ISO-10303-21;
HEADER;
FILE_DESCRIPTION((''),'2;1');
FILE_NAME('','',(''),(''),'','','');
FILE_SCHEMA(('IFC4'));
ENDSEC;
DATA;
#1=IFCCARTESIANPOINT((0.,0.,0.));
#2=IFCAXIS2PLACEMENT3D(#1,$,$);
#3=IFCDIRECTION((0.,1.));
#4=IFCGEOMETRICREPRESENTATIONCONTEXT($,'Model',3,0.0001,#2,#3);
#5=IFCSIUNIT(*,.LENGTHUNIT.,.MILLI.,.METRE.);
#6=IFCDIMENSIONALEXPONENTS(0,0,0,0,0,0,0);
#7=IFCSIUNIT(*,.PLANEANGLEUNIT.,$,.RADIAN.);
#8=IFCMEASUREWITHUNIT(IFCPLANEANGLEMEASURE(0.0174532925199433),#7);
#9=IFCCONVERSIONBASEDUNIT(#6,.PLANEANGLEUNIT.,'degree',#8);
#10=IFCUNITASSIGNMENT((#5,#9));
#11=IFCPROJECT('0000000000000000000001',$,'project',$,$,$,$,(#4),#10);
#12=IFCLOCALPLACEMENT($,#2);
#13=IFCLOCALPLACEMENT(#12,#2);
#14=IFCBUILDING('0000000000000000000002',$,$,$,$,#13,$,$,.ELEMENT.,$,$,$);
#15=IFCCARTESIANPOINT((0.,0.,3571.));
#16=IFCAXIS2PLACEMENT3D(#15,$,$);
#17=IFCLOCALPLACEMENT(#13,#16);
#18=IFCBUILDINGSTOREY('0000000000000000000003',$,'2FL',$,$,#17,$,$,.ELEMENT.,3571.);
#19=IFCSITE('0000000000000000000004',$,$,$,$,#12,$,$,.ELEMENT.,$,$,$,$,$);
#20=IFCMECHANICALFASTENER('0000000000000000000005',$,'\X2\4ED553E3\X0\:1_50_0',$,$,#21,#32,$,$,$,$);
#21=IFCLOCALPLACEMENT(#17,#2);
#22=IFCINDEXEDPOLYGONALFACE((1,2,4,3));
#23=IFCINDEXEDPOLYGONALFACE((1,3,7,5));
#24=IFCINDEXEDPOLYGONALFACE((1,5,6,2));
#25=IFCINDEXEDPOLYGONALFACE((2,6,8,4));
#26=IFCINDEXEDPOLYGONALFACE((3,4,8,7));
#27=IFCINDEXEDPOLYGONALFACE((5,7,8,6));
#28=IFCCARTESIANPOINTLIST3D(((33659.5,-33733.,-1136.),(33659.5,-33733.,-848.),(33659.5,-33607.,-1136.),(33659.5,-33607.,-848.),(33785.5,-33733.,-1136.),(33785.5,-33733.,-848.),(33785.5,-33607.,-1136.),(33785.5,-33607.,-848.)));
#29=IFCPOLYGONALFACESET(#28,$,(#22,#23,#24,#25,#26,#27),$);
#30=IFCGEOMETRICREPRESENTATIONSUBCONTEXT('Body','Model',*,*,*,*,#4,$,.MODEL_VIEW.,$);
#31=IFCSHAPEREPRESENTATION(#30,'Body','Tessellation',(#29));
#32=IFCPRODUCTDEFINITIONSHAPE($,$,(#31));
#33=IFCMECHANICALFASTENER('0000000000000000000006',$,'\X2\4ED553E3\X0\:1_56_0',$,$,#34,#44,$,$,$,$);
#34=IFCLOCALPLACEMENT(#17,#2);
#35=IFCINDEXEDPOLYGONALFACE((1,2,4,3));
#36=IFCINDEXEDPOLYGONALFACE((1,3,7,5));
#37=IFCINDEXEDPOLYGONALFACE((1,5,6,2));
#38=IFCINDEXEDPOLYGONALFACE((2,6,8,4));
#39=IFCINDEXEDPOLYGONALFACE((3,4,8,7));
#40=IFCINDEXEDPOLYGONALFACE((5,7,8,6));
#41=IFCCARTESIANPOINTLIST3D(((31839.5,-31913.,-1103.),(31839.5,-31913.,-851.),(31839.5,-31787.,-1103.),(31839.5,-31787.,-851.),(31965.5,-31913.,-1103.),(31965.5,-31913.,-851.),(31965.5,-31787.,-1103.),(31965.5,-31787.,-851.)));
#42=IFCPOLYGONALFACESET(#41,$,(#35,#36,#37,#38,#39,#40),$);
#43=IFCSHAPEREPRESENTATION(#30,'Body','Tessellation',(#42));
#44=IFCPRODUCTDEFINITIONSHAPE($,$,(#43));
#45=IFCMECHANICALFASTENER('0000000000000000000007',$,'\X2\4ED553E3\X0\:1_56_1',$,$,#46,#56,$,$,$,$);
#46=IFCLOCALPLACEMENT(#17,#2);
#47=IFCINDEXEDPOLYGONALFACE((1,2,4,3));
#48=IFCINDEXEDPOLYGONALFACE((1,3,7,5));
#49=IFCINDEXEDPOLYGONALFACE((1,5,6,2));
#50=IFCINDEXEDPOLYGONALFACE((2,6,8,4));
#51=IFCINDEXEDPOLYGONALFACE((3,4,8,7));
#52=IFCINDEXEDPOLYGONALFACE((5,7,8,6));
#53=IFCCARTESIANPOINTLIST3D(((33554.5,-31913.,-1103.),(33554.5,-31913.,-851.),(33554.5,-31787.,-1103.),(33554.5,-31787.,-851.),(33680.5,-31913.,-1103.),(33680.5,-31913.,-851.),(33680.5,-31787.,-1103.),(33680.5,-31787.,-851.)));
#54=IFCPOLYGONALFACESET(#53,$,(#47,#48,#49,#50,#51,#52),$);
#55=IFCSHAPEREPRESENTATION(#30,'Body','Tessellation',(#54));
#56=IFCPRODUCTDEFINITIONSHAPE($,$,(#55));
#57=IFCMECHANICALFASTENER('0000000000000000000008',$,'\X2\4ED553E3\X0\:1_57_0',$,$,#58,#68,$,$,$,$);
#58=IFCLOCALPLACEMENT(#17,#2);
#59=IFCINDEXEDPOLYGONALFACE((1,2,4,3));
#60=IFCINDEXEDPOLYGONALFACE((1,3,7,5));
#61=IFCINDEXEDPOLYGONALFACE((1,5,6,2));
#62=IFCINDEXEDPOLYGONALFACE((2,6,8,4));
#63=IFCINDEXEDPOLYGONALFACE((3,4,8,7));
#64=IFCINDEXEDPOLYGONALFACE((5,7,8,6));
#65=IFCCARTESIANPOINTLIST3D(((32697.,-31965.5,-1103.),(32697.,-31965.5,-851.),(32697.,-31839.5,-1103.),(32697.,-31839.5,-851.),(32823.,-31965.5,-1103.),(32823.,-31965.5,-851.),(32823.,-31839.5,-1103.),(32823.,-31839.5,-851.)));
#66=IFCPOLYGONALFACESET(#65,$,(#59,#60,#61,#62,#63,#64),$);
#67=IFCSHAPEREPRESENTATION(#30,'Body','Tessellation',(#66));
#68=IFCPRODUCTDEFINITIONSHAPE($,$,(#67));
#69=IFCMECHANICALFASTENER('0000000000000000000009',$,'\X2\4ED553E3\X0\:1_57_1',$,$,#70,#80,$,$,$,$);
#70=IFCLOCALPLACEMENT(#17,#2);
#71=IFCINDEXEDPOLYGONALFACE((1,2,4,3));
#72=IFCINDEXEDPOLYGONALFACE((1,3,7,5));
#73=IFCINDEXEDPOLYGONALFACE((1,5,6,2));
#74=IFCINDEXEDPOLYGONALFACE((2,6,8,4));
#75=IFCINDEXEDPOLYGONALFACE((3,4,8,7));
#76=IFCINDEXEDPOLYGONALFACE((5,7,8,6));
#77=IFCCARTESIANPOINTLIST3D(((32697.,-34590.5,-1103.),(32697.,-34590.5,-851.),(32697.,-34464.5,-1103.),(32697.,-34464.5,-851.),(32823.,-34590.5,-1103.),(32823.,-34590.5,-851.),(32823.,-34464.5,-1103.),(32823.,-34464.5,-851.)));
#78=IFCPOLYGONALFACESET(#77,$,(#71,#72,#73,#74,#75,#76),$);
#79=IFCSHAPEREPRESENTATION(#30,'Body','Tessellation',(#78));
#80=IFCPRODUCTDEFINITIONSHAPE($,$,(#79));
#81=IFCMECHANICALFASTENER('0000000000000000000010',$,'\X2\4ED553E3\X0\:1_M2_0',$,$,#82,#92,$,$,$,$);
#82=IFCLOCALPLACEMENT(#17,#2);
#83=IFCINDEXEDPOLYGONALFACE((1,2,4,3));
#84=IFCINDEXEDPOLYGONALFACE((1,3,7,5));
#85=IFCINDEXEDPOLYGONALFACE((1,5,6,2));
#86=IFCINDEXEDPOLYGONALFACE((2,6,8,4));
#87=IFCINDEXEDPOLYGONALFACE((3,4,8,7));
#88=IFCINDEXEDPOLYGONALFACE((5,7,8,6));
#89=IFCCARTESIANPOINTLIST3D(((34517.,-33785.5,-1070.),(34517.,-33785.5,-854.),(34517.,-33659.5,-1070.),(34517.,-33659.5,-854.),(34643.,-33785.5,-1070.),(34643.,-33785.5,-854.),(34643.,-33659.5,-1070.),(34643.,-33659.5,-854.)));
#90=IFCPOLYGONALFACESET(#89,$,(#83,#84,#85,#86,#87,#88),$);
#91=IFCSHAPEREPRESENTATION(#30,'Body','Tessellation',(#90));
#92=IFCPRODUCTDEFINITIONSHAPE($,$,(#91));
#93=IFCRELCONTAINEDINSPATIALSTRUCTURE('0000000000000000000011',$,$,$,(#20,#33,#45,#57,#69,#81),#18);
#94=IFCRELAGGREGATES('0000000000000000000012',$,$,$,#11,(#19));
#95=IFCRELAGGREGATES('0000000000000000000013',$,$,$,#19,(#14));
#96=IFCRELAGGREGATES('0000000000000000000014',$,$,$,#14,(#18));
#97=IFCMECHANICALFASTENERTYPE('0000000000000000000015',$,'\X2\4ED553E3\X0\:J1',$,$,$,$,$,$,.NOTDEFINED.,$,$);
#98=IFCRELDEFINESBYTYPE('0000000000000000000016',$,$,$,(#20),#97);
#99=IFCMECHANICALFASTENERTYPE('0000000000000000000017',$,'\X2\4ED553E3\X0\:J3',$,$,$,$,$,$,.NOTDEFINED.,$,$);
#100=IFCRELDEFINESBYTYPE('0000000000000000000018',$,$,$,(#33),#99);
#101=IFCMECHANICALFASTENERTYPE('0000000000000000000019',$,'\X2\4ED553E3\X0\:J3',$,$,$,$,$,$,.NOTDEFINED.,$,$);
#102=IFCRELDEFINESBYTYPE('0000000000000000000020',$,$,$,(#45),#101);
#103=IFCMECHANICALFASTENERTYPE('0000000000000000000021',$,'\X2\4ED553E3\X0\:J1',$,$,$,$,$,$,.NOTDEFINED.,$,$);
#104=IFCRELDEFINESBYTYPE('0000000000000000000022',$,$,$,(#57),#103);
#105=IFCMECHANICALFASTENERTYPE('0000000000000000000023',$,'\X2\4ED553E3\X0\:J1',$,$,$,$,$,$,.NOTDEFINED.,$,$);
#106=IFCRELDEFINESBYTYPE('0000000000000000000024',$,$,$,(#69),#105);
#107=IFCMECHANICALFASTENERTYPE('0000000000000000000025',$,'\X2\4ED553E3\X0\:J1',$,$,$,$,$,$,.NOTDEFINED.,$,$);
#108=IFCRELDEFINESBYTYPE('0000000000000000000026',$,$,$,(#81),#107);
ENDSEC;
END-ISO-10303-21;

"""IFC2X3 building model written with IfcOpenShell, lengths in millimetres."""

from ifc_helpers import new_model, entity, si_unit, converted_unit, direction, frame, origin, origin_with_axes, origin_2d, place, context, subcontext, project, spatial, rectangle, extrude, type_object, element, save


model = new_model("IFC2X3")

# Units and contexts
model_context = context("Model", 3, precision=0.0001, world=origin(), true_north=direction((0.0, 1.0)))
body_context = subcontext(model_context, "Body", "Model", "MODEL_VIEW")
ifc_project = project(units=[si_unit("LENGTHUNIT", "METRE", prefix="MILLI"), converted_unit("PLANEANGLEUNIT", "degree", entity("IfcPlaneAngleMeasure", 0.0174532925199433), si_unit("PLANEANGLEUNIT", "RADIAN"), dimensions=[0, 0, 0, 0, 0, 0, 0])], contexts=[model_context])

# Site, building, storey
site_placement = place(None, origin())
site = spatial("IfcSite", under=ifc_project, at=site_placement, CompositionType="ELEMENT")
building_placement = place(site_placement, origin())
building = spatial("IfcBuilding", under=site, at=building_placement, CompositionType="ELEMENT")
storey_placement = place(building_placement, frame((0.0, 0.0, 3571.0)))
storey = spatial("IfcBuildingStorey", under=building, at=storey_placement, Name="2FL", CompositionType="ELEMENT", Elevation=3571.0)

# Mechanical fasteners
mechanical_fastener_type_1 = type_object("IfcMechanicalFastenerType", Name="仕口:J1")
mechanical_fastener_1_placement = place(storey_placement, frame((33722.5, -33670.0, -1136.0)))
element("IfcMechanicalFastener", 1, at=mechanical_fastener_1_placement, inside=storey, type_object=mechanical_fastener_type_1, Name="仕口:1_50_0", context=body_context, shape_type="SweptSolid", body=[
    extrude(rectangle(XDim=126.0, YDim=126.0, at=origin_2d()), origin_with_axes(), (0.0, 0.0, 1.0), 288.0),
])
mechanical_fastener_type_2 = type_object("IfcMechanicalFastenerType", Name="仕口:J3")
mechanical_fastener_2_placement = place(storey_placement, frame((31902.5, -31850.0, -1103.0)))
element("IfcMechanicalFastener", 2, at=mechanical_fastener_2_placement, inside=storey, type_object=mechanical_fastener_type_2, Name="仕口:1_56_0", context=body_context, shape_type="SweptSolid", body=[
    extrude(rectangle(XDim=126.0, YDim=126.0, at=origin_2d()), origin_with_axes(), (0.0, 0.0, 1.0), 252.0),
])
mechanical_fastener_type_3 = type_object("IfcMechanicalFastenerType", Name="仕口:J3")
mechanical_fastener_3_placement = place(storey_placement, frame((33617.5, -31850.0, -1103.0)))
element("IfcMechanicalFastener", 3, at=mechanical_fastener_3_placement, inside=storey, type_object=mechanical_fastener_type_3, Name="仕口:1_56_1", context=body_context, shape_type="SweptSolid", body=[
    extrude(rectangle(XDim=126.0, YDim=126.0, at=origin_2d()), origin_with_axes(), (0.0, 0.0, 1.0), 252.0),
])
mechanical_fastener_type_4 = type_object("IfcMechanicalFastenerType", Name="仕口:J1")
mechanical_fastener_4_placement = place(storey_placement, frame((32760.0, -31902.5, -1103.0)))
element("IfcMechanicalFastener", 4, at=mechanical_fastener_4_placement, inside=storey, type_object=mechanical_fastener_type_4, Name="仕口:1_57_0", context=body_context, shape_type="SweptSolid", body=[
    extrude(rectangle(XDim=126.0, YDim=126.0, at=origin_2d()), origin_with_axes(), (0.0, 0.0, 1.0), 252.0),
])
mechanical_fastener_type_5 = type_object("IfcMechanicalFastenerType", Name="仕口:J1")
mechanical_fastener_5_placement = place(storey_placement, frame((32760.0, -34527.5, -1103.0)))
element("IfcMechanicalFastener", 5, at=mechanical_fastener_5_placement, inside=storey, type_object=mechanical_fastener_type_5, Name="仕口:1_57_1", context=body_context, shape_type="SweptSolid", body=[
    extrude(rectangle(XDim=126.0, YDim=126.0, at=origin_2d()), origin_with_axes(), (0.0, 0.0, 1.0), 252.0),
])
mechanical_fastener_type_6 = type_object("IfcMechanicalFastenerType", Name="仕口:J1")
mechanical_fastener_6_placement = place(storey_placement, frame((34580.0, -33722.5, -1070.0)))
element("IfcMechanicalFastener", 6, at=mechanical_fastener_6_placement, inside=storey, type_object=mechanical_fastener_type_6, Name="仕口:1_M2_0", context=body_context, shape_type="SweptSolid", body=[
    extrude(rectangle(XDim=126.0, YDim=126.0, at=origin_2d()), origin_with_axes(), (0.0, 0.0, 1.0), 216.0),
])

save(model, "model.ifc")
